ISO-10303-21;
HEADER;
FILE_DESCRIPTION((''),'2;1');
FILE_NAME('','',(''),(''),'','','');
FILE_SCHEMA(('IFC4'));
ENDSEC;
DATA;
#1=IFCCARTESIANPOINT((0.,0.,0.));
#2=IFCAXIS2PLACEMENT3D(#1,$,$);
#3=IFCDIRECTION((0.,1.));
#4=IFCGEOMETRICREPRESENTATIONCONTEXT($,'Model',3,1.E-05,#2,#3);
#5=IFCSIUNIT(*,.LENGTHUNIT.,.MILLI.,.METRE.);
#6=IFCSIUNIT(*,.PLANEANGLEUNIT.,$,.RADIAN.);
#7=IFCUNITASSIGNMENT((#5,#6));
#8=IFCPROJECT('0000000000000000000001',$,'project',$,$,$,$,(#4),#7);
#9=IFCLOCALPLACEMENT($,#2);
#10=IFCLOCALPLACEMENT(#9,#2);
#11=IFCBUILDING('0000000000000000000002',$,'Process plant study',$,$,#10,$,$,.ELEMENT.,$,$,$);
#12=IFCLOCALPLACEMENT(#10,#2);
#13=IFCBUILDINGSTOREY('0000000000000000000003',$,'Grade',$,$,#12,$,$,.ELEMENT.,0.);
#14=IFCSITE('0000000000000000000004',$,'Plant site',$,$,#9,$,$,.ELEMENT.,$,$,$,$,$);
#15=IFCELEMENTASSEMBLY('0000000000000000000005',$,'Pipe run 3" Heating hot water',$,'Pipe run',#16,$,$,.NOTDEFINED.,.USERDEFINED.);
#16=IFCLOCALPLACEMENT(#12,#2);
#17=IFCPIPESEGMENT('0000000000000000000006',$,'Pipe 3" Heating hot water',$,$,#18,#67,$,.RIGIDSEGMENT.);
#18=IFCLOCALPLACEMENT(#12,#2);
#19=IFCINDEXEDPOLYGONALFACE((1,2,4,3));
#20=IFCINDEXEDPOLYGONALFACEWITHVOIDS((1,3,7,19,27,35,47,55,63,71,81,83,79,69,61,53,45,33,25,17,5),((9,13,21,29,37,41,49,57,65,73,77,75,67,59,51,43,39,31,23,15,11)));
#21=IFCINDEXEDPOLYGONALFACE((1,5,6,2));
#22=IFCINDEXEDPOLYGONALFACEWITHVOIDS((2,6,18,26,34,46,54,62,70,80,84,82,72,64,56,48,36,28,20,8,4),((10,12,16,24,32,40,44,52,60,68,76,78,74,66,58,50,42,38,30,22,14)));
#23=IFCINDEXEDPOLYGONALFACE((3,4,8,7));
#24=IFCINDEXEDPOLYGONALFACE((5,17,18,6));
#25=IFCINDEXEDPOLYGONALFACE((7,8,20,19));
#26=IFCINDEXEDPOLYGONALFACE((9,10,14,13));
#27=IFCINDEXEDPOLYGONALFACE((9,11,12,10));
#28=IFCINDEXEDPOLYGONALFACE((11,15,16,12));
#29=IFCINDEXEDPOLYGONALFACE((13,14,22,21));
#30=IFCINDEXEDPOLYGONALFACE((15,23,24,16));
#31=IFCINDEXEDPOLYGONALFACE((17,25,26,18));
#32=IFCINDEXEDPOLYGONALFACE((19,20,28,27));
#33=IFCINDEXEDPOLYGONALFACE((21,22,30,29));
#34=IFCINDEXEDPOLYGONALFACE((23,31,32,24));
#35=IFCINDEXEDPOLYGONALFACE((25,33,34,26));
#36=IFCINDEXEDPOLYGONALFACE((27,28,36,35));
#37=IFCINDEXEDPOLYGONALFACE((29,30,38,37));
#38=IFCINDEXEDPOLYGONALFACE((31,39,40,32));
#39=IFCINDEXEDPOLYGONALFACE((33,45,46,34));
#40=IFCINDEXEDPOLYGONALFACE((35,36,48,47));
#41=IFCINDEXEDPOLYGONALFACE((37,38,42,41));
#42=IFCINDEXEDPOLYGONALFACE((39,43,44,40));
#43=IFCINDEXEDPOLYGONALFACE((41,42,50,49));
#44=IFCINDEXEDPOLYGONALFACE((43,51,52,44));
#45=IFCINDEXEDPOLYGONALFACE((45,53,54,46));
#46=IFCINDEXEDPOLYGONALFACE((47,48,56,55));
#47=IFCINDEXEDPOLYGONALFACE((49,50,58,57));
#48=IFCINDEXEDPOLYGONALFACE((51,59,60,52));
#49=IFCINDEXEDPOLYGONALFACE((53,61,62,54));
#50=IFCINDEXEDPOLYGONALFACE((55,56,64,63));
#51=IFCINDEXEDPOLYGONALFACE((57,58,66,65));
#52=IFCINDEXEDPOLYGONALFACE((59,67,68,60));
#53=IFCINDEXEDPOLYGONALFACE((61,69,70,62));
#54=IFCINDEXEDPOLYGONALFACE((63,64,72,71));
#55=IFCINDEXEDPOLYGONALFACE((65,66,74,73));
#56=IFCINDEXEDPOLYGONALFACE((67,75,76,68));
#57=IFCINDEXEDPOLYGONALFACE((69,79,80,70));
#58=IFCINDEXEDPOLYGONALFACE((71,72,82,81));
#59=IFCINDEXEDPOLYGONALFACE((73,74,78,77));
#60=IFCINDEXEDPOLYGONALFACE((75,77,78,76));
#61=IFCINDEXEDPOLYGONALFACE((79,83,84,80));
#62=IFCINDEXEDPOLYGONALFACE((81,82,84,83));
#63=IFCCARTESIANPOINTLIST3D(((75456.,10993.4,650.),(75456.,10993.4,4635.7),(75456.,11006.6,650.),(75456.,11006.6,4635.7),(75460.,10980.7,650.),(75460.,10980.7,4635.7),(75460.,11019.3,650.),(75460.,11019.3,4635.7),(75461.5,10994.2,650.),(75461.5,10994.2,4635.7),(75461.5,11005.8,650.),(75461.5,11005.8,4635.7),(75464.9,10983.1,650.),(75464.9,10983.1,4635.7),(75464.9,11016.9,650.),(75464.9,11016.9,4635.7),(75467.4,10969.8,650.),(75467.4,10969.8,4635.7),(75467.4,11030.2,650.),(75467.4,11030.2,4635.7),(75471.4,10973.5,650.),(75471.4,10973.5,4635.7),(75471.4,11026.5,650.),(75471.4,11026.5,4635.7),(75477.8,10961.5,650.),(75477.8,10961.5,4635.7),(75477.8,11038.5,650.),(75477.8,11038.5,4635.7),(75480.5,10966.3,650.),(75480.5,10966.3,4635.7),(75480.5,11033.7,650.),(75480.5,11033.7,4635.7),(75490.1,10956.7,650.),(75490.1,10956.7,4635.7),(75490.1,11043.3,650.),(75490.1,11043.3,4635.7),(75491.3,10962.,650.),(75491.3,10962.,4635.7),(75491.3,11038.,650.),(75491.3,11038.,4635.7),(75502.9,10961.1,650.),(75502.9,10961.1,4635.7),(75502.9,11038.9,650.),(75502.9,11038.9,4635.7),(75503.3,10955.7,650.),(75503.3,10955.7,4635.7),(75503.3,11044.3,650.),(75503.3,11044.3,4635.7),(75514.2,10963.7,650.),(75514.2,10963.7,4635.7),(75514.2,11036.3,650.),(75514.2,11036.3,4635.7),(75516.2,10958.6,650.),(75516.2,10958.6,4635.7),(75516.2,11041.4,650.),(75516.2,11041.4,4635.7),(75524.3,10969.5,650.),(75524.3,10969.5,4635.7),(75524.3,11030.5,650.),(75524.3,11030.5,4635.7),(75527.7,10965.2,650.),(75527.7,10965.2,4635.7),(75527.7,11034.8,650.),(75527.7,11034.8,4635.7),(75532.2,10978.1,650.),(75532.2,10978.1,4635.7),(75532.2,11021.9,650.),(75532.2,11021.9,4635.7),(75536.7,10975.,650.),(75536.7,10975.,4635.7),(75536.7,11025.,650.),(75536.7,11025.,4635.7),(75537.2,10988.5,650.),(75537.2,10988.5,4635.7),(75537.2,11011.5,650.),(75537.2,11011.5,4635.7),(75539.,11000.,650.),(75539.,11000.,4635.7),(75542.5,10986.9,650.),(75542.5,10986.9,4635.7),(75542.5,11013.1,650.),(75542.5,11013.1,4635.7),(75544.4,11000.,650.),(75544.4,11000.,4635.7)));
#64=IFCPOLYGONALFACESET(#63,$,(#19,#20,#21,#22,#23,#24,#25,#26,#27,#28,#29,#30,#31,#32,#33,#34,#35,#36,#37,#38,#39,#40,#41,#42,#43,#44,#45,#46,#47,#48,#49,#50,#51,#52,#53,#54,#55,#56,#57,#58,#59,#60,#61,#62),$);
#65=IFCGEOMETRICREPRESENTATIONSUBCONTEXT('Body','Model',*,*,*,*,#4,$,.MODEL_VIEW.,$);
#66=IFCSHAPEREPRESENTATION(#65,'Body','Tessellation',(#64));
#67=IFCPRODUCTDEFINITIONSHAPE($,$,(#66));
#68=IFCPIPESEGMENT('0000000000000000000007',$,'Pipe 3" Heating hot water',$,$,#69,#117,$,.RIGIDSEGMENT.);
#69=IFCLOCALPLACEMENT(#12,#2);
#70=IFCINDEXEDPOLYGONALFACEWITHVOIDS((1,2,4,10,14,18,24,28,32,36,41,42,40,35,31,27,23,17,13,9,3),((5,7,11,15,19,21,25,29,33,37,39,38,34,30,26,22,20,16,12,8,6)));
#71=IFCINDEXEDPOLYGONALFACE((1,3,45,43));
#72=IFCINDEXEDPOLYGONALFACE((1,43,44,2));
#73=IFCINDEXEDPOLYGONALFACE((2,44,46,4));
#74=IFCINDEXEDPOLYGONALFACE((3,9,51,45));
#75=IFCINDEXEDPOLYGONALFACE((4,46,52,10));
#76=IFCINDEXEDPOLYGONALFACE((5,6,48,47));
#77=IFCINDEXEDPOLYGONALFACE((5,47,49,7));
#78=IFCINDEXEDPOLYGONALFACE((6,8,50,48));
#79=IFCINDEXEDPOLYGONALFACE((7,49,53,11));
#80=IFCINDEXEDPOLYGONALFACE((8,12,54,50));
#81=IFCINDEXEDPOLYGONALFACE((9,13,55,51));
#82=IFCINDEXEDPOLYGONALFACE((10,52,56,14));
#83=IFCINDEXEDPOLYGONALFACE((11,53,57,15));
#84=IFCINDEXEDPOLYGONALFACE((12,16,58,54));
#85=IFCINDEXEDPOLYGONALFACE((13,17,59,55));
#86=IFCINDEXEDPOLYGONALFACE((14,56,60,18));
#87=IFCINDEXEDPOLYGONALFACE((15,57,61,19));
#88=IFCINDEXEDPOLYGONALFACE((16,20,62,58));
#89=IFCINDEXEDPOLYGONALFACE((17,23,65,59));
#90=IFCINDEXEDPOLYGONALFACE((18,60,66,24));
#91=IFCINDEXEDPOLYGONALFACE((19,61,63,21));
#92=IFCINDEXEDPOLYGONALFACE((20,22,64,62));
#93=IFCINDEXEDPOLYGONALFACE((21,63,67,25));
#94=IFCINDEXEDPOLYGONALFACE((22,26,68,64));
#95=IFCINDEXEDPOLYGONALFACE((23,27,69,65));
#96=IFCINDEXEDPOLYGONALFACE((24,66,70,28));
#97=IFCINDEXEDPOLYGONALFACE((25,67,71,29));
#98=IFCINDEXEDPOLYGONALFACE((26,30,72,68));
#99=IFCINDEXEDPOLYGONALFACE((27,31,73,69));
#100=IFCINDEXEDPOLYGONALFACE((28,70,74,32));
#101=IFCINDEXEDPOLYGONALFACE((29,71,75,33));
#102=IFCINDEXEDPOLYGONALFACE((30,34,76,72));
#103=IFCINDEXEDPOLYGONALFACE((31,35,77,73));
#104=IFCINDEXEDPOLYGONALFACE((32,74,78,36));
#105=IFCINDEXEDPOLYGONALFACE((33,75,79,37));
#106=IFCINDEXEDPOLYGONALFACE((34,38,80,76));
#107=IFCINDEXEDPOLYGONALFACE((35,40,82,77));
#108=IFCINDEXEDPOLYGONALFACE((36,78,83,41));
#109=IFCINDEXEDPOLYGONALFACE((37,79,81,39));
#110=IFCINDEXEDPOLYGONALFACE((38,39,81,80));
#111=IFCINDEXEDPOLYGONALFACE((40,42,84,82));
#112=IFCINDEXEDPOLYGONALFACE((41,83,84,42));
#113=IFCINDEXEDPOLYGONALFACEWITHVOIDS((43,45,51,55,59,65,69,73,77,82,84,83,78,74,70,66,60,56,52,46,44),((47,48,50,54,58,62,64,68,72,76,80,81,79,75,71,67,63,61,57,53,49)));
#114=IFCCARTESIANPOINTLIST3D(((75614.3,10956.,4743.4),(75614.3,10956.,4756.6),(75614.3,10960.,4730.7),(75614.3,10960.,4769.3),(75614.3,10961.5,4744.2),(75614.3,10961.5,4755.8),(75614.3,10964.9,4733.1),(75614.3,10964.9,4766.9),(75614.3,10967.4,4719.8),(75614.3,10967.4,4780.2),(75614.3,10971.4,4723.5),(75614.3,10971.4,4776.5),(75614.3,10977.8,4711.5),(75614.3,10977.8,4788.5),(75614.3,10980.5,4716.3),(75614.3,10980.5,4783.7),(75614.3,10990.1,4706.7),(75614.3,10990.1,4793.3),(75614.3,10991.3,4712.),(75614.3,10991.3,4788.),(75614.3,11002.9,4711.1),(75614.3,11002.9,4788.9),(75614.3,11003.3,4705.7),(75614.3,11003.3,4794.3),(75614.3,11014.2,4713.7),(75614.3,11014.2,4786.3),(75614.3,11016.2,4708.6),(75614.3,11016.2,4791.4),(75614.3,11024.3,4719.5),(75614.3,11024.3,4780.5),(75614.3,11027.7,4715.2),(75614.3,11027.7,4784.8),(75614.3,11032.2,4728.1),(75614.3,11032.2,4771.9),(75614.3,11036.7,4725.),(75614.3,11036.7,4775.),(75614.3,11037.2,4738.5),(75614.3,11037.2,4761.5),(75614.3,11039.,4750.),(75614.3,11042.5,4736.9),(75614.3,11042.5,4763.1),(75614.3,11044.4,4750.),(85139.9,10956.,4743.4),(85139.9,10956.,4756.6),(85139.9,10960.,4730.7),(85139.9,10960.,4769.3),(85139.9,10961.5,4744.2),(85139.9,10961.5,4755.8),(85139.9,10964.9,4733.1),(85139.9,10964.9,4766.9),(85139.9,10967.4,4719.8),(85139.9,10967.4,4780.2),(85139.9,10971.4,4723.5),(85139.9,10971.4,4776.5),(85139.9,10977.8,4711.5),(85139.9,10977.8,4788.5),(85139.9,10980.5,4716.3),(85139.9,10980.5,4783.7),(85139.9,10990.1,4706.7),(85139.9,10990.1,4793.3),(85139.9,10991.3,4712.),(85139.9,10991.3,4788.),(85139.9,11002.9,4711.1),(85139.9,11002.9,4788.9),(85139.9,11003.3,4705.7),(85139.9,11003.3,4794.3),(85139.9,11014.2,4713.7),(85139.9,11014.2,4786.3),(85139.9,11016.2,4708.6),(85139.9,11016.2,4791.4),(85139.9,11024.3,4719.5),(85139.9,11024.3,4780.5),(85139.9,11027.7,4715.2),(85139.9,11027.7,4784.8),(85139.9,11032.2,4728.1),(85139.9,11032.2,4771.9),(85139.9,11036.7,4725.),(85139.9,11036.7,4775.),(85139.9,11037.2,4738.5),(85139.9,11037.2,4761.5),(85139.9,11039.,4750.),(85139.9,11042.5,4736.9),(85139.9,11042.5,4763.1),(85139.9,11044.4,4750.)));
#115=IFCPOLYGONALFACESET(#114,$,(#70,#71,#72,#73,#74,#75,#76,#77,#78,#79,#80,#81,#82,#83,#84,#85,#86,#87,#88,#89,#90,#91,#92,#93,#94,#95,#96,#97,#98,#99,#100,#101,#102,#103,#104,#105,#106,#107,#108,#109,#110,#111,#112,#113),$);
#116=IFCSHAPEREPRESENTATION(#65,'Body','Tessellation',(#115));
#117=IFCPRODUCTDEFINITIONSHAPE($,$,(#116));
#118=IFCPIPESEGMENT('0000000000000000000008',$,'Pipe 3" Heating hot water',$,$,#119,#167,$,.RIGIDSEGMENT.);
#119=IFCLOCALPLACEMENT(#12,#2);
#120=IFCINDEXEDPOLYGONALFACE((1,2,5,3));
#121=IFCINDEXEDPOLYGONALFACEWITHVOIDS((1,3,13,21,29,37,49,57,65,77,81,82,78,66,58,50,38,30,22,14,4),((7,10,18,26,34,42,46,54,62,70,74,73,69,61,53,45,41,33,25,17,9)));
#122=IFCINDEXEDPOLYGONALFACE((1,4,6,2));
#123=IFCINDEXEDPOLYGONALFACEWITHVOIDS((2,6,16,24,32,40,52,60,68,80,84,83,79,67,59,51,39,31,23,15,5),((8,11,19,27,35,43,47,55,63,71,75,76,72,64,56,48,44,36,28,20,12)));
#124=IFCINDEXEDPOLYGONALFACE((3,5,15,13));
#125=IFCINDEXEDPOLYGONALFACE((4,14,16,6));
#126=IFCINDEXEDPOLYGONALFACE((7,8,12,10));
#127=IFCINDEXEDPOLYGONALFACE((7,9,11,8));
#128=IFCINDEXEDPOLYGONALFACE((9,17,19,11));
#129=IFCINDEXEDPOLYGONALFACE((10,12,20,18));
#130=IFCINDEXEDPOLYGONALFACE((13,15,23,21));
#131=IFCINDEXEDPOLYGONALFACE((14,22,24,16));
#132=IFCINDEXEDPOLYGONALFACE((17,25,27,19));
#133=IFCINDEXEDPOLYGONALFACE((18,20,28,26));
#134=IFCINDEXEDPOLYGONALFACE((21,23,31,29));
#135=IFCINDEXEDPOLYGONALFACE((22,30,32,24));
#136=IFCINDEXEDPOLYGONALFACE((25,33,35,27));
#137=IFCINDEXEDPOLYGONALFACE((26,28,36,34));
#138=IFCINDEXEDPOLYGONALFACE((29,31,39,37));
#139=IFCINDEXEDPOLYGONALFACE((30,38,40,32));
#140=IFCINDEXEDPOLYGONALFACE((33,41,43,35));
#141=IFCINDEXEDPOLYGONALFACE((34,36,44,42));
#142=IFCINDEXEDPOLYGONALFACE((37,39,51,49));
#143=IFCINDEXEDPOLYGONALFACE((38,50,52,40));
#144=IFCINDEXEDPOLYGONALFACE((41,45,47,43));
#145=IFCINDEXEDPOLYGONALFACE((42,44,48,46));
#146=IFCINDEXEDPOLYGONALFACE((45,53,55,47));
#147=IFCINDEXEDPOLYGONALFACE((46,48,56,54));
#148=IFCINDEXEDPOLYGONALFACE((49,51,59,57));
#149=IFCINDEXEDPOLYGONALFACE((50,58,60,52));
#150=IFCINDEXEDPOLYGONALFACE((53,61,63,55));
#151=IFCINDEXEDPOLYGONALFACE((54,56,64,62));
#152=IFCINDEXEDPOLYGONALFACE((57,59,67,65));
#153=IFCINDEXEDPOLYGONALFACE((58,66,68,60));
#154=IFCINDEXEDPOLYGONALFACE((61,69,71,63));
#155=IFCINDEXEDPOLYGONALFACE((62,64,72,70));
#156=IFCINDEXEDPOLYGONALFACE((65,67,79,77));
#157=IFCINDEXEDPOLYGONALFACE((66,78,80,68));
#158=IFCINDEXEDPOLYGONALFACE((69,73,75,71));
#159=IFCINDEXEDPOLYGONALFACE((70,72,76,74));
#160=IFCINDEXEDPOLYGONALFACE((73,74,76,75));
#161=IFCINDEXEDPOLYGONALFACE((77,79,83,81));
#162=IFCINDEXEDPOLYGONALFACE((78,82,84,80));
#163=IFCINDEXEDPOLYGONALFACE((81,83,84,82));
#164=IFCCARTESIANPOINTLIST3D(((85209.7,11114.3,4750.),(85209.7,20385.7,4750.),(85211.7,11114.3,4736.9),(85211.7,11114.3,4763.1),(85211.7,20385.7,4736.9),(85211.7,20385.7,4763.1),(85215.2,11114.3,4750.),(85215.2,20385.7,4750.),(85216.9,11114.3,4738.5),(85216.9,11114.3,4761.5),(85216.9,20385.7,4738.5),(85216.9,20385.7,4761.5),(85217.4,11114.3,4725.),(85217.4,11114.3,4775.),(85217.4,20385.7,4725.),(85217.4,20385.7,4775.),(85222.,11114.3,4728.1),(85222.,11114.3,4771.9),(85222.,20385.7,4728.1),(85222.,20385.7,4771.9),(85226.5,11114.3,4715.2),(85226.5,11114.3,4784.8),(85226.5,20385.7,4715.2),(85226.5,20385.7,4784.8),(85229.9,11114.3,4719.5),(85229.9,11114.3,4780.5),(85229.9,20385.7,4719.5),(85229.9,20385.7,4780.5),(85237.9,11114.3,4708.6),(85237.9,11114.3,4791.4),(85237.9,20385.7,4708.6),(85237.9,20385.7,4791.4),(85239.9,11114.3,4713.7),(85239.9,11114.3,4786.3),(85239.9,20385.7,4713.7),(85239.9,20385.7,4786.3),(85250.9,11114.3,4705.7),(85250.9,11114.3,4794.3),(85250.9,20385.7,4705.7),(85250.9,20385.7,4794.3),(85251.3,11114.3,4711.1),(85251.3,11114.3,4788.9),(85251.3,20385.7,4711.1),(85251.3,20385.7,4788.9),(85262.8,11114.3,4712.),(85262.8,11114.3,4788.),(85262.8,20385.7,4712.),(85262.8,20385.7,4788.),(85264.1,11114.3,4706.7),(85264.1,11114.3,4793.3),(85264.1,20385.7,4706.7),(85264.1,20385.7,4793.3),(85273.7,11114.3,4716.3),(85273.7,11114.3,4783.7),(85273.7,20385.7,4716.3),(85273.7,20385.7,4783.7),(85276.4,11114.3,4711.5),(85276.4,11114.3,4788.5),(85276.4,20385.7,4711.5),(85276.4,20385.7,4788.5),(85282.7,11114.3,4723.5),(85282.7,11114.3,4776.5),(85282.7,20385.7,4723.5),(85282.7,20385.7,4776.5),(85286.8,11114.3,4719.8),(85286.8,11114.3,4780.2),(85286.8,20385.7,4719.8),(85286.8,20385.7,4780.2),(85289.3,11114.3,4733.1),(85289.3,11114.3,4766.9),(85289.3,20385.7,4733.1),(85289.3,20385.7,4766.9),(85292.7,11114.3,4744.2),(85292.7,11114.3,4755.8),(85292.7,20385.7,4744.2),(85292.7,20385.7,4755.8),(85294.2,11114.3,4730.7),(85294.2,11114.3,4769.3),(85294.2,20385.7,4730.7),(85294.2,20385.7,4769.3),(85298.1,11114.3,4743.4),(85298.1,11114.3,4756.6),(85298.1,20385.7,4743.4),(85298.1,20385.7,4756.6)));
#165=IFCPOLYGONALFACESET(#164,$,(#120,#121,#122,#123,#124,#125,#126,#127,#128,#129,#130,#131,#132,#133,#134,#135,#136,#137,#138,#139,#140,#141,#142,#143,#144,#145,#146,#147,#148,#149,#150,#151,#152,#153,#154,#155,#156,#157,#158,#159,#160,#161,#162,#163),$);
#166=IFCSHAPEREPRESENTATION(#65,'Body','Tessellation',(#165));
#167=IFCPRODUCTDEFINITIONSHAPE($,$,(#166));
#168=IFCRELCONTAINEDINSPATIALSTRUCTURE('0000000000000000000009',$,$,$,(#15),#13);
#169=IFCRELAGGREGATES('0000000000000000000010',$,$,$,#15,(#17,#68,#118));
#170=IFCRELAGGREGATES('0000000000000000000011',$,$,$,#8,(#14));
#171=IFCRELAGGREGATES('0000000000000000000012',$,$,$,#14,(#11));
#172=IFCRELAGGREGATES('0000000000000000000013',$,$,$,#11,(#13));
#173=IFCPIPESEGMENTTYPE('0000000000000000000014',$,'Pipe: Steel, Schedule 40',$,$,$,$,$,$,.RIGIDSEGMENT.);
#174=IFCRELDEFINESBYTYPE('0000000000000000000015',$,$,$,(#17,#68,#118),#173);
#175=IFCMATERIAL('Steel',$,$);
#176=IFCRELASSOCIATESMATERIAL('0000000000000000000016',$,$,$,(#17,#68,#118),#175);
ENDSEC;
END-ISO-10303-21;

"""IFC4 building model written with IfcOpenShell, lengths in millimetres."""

from ifc_helpers import new_model, si_unit, direction, frame, origin, origin_with_axes, origin_2d, place, context, subcontext, project, spatial, hollow_circle, extrude, material, type_object, element, aggregate, save


model = new_model("IFC4")

# Units and contexts
model_context = context("Model", 3, precision=1e-05, world=origin(), true_north=direction((0.0, 1.0)))
body_context = subcontext(model_context, "Body", "Model", "MODEL_VIEW")
ifc_project = project(units=[si_unit("LENGTHUNIT", "METRE", prefix="MILLI"), si_unit("PLANEANGLEUNIT", "RADIAN")], contexts=[model_context])

# Site, building, storey
site_placement = place(None, origin())
site = spatial("IfcSite", under=ifc_project, at=site_placement, Name="Plant site", CompositionType="ELEMENT")
building_placement = place(site_placement, origin())
building = spatial("IfcBuilding", under=site, at=building_placement, Name="Process plant study", CompositionType="ELEMENT")
storey_placement = place(building_placement, origin())
storey = spatial("IfcBuildingStorey", under=building, at=storey_placement, Name="Grade", CompositionType="ELEMENT", Elevation=0.0)

# Element assembly, pipe segments
ifc_material = material(Name="Steel")
pipe_segment_type = type_object("IfcPipeSegmentType", Name="Pipe: Steel, Schedule 40", PredefinedType="RIGIDSEGMENT")
assembly_1_placement = place(storey_placement, origin_with_axes())
assembly_1 = element("IfcElementAssembly", 1, at=assembly_1_placement, inside=storey, Name="Pipe run 3\" Heating hot water", ObjectType="Pipe run", AssemblyPlace="NOTDEFINED", PredefinedType="USERDEFINED")
pipe_segment_1_placement = place(storey_placement, origin_with_axes())
pipe_segment_1 = element("IfcPipeSegment", 2, at=pipe_segment_1_placement, type_object=pipe_segment_type, material=ifc_material, Name="Pipe 3\" Heating hot water", PredefinedType="RIGIDSEGMENT", context=body_context, shape_type="SweptSolid", body=[
    extrude(hollow_circle(Radius=44.5, WallThickness=5.5, at=origin_2d()), frame((75500.0, 11000.0, 650.0), z_axis=(0.0, 0.0, 1.0), x_axis=(1.0, 0.0, 0.0)), (0.0, 0.0, 1.0), 3985.7),
])
pipe_segment_2_placement = place(storey_placement, origin_with_axes())
pipe_segment_2 = element("IfcPipeSegment", 3, at=pipe_segment_2_placement, type_object=pipe_segment_type, material=ifc_material, Name="Pipe 3\" Heating hot water", PredefinedType="RIGIDSEGMENT", context=body_context, shape_type="SweptSolid", body=[
    extrude(hollow_circle(Radius=44.5, WallThickness=5.5, at=origin_2d()), frame((75614.3, 11000.0, 4750.0), z_axis=(1.0, 0.0, 0.0), x_axis=(0.0, 1.0, 0.0)), (0.0, 0.0, 1.0), 9525.6),
])
pipe_segment_3_placement = place(storey_placement, origin_with_axes())
pipe_segment_3 = element("IfcPipeSegment", 4, at=pipe_segment_3_placement, type_object=pipe_segment_type, material=ifc_material, Name="Pipe 3\" Heating hot water", PredefinedType="RIGIDSEGMENT", context=body_context, shape_type="SweptSolid", body=[
    extrude(hollow_circle(Radius=44.5, WallThickness=5.5, at=origin_2d()), frame((85254.2, 11114.3, 4750.0), z_axis=(0.0, 1.0, 0.0), x_axis=(-1.0, 0.0, 0.0)), (0.0, 0.0, 1.0), 9271.4),
])

aggregate(assembly_1, [pipe_segment_1, pipe_segment_2, pipe_segment_3])

save(model, "model.ifc")
